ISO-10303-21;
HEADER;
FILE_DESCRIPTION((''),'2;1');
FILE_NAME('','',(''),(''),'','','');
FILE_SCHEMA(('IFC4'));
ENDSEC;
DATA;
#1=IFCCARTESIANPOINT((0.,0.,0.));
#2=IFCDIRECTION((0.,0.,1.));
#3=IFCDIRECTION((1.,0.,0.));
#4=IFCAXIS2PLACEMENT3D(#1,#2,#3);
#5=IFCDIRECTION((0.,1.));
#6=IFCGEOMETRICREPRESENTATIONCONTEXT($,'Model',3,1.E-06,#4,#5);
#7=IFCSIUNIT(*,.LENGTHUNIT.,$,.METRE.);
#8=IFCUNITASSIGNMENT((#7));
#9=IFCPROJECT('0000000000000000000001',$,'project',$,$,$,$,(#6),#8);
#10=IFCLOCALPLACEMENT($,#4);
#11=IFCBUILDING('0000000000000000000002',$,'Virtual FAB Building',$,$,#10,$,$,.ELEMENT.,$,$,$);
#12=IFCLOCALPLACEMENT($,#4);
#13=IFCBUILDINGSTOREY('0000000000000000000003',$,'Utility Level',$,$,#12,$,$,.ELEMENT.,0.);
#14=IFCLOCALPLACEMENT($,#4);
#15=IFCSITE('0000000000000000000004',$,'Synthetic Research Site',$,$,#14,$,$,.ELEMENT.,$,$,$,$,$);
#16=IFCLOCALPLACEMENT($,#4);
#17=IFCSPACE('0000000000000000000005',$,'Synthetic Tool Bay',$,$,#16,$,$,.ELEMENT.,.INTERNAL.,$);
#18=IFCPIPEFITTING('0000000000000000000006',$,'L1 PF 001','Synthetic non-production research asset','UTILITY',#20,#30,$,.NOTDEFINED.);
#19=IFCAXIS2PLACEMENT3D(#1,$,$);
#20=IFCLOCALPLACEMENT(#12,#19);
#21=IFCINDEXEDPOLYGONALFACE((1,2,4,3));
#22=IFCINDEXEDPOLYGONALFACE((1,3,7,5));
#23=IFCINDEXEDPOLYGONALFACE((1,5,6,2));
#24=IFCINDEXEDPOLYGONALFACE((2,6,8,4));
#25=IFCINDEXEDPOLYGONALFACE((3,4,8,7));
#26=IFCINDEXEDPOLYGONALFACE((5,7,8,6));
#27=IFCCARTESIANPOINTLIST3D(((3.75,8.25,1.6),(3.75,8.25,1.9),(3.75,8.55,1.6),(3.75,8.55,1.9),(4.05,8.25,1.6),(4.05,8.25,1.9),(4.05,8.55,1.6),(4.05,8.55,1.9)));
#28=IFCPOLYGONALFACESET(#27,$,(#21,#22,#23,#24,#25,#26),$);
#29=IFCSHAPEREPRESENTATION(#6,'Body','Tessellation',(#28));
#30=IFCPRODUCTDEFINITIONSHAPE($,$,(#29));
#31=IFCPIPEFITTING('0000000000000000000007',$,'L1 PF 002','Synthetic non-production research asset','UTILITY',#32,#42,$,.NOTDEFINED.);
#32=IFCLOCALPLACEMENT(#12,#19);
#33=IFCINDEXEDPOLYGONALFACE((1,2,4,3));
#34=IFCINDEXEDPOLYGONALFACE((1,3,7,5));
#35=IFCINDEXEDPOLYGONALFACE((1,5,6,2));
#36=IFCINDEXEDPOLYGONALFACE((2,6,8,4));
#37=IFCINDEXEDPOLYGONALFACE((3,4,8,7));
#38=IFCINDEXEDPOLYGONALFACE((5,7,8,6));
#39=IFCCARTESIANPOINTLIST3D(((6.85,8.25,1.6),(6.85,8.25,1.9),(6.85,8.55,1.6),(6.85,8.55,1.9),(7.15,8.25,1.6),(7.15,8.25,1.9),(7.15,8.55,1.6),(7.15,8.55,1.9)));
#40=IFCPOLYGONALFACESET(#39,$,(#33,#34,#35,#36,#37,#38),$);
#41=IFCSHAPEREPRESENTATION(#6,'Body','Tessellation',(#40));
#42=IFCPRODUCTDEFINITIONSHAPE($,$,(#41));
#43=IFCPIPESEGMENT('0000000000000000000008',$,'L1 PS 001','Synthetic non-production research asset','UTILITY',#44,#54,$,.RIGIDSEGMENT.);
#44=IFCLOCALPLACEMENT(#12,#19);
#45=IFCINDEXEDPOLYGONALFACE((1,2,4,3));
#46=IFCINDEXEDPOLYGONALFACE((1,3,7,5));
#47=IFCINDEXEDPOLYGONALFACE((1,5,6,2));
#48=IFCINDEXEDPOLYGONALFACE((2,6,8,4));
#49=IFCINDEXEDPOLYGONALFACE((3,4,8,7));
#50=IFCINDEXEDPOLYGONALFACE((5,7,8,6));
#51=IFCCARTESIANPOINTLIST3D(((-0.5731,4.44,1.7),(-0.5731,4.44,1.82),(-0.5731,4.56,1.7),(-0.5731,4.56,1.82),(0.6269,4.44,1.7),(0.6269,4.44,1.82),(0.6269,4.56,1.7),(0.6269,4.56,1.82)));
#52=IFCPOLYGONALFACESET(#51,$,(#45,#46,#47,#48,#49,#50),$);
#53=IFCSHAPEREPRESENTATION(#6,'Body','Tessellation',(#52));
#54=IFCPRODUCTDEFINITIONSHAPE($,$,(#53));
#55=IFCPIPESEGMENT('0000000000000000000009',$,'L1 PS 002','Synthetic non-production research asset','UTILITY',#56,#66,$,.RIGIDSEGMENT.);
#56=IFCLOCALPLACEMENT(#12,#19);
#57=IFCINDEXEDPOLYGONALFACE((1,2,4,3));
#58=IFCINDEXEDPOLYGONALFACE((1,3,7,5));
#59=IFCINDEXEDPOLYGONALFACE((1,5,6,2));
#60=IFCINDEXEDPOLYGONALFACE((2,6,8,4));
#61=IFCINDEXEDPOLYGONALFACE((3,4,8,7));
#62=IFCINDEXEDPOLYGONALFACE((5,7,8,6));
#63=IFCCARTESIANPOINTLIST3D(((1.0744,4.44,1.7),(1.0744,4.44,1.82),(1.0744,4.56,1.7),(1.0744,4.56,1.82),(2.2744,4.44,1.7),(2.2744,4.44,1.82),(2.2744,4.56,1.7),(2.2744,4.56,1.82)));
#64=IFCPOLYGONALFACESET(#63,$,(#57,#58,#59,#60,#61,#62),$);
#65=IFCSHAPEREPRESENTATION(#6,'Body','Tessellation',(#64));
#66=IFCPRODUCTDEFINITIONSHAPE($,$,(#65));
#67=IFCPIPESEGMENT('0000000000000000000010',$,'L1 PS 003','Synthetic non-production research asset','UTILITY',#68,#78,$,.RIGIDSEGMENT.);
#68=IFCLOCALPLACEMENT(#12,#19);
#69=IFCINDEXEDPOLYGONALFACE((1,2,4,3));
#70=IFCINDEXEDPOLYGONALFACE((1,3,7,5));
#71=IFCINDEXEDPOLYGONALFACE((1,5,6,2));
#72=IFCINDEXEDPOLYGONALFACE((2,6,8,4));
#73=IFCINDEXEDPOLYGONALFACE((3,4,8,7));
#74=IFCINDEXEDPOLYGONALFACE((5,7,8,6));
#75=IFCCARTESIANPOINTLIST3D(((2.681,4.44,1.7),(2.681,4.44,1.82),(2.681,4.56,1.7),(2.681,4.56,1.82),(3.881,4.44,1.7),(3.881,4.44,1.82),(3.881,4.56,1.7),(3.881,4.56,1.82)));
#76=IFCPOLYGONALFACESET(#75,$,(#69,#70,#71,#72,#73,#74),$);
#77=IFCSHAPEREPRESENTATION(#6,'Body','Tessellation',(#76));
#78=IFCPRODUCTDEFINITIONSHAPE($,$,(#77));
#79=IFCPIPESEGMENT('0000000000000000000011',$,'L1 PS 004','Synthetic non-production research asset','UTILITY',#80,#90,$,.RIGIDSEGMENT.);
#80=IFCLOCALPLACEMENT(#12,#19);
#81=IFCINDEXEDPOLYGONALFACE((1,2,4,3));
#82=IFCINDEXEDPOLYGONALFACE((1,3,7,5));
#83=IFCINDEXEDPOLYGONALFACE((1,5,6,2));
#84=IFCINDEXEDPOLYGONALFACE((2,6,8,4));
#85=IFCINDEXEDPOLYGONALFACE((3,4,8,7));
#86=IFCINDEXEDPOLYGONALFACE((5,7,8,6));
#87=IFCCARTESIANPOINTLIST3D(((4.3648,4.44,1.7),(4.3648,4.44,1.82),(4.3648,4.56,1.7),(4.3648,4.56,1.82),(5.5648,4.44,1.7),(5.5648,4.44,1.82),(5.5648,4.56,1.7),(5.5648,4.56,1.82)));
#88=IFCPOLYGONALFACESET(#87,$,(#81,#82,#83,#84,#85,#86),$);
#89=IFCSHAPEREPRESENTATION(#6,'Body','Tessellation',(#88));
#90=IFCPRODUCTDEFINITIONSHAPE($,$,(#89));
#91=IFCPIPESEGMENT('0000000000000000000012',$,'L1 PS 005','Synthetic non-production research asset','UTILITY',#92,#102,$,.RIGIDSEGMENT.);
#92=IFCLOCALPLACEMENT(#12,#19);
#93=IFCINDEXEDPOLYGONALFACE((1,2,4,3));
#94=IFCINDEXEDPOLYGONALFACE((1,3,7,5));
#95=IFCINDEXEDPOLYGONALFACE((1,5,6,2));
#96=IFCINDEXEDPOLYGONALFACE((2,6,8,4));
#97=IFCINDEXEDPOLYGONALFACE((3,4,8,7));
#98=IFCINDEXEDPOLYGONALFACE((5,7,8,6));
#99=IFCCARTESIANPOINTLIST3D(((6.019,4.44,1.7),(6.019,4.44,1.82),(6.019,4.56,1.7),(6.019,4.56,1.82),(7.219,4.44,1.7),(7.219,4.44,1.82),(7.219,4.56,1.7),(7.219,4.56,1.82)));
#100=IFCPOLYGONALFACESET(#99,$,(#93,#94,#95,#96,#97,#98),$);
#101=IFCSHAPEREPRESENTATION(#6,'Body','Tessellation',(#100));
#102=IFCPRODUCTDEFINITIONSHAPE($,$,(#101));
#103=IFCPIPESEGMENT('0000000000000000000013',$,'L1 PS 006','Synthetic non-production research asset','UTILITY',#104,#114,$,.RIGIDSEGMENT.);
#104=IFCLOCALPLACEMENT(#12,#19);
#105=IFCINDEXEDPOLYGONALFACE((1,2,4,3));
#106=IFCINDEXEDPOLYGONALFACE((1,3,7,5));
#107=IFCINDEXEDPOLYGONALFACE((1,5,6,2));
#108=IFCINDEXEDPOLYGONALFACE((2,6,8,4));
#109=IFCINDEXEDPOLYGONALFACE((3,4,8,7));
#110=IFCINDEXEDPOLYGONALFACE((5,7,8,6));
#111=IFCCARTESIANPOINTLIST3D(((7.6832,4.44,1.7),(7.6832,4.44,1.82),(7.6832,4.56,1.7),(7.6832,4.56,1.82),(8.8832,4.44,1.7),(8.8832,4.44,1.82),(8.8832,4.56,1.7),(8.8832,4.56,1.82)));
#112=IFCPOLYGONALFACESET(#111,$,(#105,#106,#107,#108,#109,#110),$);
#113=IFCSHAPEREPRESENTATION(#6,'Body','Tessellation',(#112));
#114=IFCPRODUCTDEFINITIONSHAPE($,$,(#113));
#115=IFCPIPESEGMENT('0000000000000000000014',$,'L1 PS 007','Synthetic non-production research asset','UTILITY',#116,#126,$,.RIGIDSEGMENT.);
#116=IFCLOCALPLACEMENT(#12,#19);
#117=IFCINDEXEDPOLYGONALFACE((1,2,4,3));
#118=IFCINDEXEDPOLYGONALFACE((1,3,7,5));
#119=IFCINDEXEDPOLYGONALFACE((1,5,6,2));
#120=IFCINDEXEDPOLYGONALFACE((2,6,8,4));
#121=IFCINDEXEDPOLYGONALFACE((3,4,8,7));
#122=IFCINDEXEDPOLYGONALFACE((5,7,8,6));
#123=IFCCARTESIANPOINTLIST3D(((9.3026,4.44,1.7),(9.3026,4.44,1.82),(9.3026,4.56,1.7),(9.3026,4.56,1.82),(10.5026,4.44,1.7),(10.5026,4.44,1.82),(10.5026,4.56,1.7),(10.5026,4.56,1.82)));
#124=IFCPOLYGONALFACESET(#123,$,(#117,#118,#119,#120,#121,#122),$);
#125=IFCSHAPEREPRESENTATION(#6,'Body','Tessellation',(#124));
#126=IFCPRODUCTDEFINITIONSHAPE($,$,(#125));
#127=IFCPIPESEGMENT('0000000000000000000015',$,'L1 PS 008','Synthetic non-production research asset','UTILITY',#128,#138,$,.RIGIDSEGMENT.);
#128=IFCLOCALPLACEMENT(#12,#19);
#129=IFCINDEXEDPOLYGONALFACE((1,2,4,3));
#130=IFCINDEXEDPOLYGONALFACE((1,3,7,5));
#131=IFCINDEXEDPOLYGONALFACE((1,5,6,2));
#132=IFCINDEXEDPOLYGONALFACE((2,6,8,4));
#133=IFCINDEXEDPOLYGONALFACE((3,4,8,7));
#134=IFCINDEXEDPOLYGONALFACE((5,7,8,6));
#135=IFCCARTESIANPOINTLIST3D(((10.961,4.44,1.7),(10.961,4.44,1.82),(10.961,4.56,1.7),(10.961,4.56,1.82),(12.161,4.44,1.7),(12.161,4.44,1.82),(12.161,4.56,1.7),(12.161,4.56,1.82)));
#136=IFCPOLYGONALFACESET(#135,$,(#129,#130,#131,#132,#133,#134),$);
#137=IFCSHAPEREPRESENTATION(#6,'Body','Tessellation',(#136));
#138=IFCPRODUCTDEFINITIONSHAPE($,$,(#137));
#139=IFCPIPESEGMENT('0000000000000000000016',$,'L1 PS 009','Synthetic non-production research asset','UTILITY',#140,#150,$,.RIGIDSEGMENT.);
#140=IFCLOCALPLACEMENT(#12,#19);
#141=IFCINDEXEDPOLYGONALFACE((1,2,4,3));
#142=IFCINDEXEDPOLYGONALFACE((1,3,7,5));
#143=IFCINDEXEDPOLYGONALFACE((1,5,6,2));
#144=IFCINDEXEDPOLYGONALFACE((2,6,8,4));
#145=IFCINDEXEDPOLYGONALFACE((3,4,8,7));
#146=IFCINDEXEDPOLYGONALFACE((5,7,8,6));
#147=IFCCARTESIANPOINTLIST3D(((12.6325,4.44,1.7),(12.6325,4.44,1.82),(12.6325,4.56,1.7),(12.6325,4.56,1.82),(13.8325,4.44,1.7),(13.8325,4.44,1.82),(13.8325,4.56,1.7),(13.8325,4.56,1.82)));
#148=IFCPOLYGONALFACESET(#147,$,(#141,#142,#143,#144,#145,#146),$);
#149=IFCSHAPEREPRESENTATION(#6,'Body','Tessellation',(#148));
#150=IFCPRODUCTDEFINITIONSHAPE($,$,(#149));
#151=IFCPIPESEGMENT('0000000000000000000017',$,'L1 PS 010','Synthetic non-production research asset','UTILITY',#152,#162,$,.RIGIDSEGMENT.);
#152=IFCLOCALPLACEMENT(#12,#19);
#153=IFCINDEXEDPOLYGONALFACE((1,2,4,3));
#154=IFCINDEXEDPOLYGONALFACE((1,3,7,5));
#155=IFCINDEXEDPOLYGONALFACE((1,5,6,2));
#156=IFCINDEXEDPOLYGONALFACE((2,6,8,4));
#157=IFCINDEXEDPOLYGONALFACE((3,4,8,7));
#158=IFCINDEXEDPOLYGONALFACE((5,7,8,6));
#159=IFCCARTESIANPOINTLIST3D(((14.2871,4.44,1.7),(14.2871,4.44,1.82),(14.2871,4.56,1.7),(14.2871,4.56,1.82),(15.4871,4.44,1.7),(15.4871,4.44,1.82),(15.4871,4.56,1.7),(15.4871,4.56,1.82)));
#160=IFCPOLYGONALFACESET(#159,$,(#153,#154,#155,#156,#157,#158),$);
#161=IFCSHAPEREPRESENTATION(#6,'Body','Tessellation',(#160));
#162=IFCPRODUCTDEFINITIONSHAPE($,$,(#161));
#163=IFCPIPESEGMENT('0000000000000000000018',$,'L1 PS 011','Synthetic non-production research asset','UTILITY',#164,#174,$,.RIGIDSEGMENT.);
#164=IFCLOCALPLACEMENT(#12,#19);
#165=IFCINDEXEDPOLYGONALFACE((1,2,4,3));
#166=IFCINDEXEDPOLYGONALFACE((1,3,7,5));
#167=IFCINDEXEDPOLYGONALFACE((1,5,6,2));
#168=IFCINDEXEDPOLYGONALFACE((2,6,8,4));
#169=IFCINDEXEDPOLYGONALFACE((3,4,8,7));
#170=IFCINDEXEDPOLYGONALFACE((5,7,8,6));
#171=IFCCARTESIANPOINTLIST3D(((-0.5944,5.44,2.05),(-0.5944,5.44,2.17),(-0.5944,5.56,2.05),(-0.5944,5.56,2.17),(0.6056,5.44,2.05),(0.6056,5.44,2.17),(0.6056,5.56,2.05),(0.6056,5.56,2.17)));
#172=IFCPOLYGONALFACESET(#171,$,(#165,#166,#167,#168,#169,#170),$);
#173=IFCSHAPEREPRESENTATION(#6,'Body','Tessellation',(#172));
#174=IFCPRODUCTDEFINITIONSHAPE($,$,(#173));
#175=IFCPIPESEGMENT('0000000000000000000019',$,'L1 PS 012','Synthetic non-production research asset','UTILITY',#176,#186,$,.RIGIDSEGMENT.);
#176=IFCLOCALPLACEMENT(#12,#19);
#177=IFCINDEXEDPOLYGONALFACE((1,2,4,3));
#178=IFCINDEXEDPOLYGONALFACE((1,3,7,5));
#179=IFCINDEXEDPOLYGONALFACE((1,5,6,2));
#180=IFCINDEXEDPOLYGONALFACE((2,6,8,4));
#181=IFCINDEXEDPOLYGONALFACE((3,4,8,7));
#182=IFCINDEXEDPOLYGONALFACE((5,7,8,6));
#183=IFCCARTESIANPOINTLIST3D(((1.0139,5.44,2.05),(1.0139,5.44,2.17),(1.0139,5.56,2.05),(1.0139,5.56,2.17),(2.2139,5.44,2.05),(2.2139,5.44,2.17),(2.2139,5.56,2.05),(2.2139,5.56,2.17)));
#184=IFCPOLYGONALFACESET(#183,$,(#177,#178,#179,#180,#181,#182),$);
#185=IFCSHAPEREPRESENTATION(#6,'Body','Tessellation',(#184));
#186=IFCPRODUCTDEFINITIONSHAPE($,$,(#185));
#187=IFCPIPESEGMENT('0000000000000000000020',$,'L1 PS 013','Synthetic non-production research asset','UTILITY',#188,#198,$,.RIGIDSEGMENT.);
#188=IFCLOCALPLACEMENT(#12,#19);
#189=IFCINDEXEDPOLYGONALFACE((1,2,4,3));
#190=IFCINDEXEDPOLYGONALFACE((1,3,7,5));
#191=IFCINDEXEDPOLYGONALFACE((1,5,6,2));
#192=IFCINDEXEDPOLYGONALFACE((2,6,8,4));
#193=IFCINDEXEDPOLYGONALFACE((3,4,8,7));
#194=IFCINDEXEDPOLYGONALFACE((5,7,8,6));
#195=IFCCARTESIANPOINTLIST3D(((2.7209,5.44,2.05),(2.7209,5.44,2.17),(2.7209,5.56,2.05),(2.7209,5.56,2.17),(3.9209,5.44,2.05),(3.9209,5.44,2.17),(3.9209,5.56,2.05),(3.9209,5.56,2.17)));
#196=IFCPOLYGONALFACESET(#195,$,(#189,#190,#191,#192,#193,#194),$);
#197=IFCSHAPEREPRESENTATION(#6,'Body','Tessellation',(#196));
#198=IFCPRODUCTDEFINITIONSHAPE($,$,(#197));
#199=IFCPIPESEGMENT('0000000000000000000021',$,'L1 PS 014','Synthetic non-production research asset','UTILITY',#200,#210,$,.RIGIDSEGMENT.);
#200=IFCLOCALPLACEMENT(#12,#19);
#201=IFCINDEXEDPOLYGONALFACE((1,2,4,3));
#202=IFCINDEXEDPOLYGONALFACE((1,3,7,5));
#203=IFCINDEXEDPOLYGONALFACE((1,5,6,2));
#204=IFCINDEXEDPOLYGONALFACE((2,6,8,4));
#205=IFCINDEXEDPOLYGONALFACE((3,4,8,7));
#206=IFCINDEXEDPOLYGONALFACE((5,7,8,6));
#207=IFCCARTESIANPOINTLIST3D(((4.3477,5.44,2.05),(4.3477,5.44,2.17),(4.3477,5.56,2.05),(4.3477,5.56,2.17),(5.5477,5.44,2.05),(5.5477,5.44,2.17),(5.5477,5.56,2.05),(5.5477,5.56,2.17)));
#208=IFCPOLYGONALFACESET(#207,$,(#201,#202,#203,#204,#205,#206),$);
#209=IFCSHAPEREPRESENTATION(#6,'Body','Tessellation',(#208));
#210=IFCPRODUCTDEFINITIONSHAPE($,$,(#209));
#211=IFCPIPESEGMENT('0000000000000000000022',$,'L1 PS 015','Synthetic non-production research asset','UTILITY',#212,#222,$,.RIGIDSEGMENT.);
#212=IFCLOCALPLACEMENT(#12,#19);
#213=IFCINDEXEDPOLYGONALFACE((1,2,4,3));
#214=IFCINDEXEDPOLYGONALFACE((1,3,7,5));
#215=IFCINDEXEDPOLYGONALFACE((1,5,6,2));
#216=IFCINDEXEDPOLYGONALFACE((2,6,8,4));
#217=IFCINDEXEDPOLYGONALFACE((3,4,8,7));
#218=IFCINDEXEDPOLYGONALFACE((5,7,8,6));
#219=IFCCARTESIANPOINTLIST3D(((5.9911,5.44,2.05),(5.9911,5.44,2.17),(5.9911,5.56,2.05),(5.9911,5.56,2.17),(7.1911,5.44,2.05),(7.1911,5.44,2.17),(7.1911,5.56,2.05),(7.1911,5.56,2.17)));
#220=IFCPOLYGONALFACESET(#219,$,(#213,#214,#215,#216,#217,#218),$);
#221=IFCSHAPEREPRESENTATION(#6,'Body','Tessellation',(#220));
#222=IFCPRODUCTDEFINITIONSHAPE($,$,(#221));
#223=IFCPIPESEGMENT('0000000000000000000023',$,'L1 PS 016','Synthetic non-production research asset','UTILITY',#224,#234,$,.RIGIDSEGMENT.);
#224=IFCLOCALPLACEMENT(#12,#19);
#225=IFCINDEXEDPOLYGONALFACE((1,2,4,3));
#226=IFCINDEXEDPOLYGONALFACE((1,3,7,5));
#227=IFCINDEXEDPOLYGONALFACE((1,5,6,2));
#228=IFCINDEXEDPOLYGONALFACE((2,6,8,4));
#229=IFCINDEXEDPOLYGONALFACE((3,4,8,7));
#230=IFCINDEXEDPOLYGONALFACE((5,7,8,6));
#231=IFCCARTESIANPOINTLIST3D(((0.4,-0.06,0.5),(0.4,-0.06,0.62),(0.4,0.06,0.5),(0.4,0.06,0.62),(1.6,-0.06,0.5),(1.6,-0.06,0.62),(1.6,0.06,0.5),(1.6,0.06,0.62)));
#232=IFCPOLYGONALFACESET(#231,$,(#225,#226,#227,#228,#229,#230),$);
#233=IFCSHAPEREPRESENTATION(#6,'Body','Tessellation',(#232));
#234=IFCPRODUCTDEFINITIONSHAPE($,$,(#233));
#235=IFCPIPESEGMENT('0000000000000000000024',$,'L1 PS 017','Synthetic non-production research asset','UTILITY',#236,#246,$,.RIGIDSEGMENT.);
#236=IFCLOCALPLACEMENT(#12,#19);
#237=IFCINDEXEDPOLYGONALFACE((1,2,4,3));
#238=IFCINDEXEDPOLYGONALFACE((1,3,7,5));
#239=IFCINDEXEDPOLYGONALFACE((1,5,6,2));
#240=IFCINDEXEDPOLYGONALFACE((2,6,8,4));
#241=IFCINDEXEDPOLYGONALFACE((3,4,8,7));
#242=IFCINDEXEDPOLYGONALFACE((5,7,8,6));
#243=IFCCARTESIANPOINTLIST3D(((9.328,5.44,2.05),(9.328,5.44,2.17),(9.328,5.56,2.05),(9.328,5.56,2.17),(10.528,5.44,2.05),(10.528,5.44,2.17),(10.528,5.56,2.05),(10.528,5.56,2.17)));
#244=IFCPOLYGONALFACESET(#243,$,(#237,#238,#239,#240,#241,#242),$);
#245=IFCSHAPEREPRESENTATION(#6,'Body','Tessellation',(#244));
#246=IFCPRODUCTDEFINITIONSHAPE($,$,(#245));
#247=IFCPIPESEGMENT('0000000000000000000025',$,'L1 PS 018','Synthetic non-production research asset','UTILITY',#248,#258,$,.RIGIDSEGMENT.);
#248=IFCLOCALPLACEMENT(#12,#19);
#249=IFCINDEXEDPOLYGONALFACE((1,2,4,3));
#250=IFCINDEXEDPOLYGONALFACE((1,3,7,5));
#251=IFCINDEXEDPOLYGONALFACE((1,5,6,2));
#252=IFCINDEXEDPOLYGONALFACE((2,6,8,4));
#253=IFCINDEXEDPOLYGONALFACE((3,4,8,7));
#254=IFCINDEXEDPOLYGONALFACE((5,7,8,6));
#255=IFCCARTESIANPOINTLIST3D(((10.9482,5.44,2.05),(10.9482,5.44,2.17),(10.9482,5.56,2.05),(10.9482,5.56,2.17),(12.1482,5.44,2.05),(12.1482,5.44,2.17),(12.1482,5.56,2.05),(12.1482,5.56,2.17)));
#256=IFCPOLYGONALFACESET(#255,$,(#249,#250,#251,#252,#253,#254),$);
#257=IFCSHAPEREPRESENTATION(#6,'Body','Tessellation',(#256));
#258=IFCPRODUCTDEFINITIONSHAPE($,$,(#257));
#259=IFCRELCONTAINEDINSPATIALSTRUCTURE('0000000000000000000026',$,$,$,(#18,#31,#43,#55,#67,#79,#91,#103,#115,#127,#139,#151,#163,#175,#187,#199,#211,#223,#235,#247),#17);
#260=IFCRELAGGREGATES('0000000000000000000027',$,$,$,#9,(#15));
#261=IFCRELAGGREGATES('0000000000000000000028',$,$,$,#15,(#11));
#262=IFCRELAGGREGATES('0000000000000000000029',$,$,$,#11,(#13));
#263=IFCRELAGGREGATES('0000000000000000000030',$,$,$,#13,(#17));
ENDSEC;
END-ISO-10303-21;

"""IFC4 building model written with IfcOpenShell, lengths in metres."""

from ifc_helpers import new_model, si_unit, direction, frame, origin_with_axes, origin_2d_with_axis, place, context, project, spatial, rectangle, extrude, element, save


model = new_model("IFC4")

# Units and contexts
model_context = context("Model", 3, precision=1e-06, world=origin_with_axes(), true_north=direction((0.0, 1.0)))
ifc_project = project(units=[si_unit("LENGTHUNIT", "METRE")], contexts=[model_context])

# Site, building, storey, space
site_placement = place(None, origin_with_axes())
site = spatial("IfcSite", under=ifc_project, at=site_placement, Name="Synthetic Research Site", CompositionType="ELEMENT")
building_placement = place(None, origin_with_axes())
building = spatial("IfcBuilding", under=site, at=building_placement, Name="Virtual FAB Building", CompositionType="ELEMENT")
storey_placement = place(None, origin_with_axes())
storey = spatial("IfcBuildingStorey", under=building, at=storey_placement, Name="Utility Level", CompositionType="ELEMENT", Elevation=0.0)
space_placement = place(None, origin_with_axes())
space = spatial("IfcSpace", under=storey, at=space_placement, Name="Synthetic Tool Bay", CompositionType="ELEMENT", PredefinedType="INTERNAL")

# Pipe fittings
for number, where, z_axis, x_axis, name in (
    (1, (3.9, 8.4, 1.6), (0.0, 0.0, 1.0), (1.0, 0.0, 0.0), "L1 PF 001"),
    (2, (7.0, 8.4, 1.6), (0.0, 0.0, 1.0), (1.0, 0.0, 0.0), "L1 PF 002"),
):
    element("IfcPipeFitting", number, at=place(None, frame(where, z_axis=z_axis, x_axis=x_axis)), inside=space, Name=name, Description="Synthetic non-production research asset", ObjectType="UTILITY", PredefinedType="NOTDEFINED", context=model_context, shape_type="SweptSolid", body=[
        extrude(rectangle(XDim=0.3, YDim=0.3, at=origin_2d_with_axis()), origin_with_axes(), (0.0, 0.0, 1.0), 0.3),
    ])

# Pipe segments
for number, where, z_axis, x_axis, name in (
    (3, (0.0269, 4.5, 1.7), (0.0, 0.0, 1.0), (1.0, 0.0, 0.0), "L1 PS 001"),
    (4, (1.6744, 4.5, 1.7), (0.0, 0.0, 1.0), (1.0, 0.0, 0.0), "L1 PS 002"),
    (5, (3.281, 4.5, 1.7), (0.0, 0.0, 1.0), (1.0, 0.0, 0.0), "L1 PS 003"),
    (6, (4.9648, 4.5, 1.7), (0.0, 0.0, 1.0), (1.0, 0.0, 0.0), "L1 PS 004"),
    (7, (6.619, 4.5, 1.7), (0.0, 0.0, 1.0), (1.0, 0.0, 0.0), "L1 PS 005"),
    (8, (8.2832, 4.5, 1.7), (0.0, 0.0, 1.0), (1.0, 0.0, 0.0), "L1 PS 006"),
    (9, (9.9026, 4.5, 1.7), (0.0, 0.0, 1.0), (1.0, 0.0, 0.0), "L1 PS 007"),
    (10, (11.561, 4.5, 1.7), (0.0, 0.0, 1.0), (1.0, 0.0, 0.0), "L1 PS 008"),
    (11, (13.2325, 4.5, 1.7), (0.0, 0.0, 1.0), (1.0, 0.0, 0.0), "L1 PS 009"),
    (12, (14.8871, 4.5, 1.7), (0.0, 0.0, 1.0), (1.0, 0.0, 0.0), "L1 PS 010"),
    (13, (0.0056, 5.5, 2.05), (0.0, 0.0, 1.0), (1.0, 0.0, 0.0), "L1 PS 011"),
    (14, (1.6139, 5.5, 2.05), (0.0, 0.0, 1.0), (1.0, 0.0, 0.0), "L1 PS 012"),
    (15, (3.3209, 5.5, 2.05), (0.0, 0.0, 1.0), (1.0, 0.0, 0.0), "L1 PS 013"),
    (16, (4.9477, 5.5, 2.05), (0.0, 0.0, 1.0), (1.0, 0.0, 0.0), "L1 PS 014"),
    (17, (6.5911, 5.5, 2.05), (0.0, 0.0, 1.0), (1.0, 0.0, 0.0), "L1 PS 015"),
    (18, (1.0, 0.0, 0.5), (0.0, 0.0, 1.0), (1.0, 0.0, 0.0), "L1 PS 016"),
    (19, (9.928, 5.5, 2.05), (0.0, 0.0, 1.0), (1.0, 0.0, 0.0), "L1 PS 017"),
    (20, (11.5482, 5.5, 2.05), (0.0, 0.0, 1.0), (1.0, 0.0, 0.0), "L1 PS 018"),
):
    element("IfcPipeSegment", number, at=place(None, frame(where, z_axis=z_axis, x_axis=x_axis)), inside=space, Name=name, Description="Synthetic non-production research asset", ObjectType="UTILITY", PredefinedType="RIGIDSEGMENT", context=model_context, shape_type="SweptSolid", body=[
        extrude(rectangle(XDim=1.2, YDim=0.12, at=origin_2d_with_axis()), origin_with_axes(), (0.0, 0.0, 1.0), 0.12),
    ])

save(model, "model.ifc")
